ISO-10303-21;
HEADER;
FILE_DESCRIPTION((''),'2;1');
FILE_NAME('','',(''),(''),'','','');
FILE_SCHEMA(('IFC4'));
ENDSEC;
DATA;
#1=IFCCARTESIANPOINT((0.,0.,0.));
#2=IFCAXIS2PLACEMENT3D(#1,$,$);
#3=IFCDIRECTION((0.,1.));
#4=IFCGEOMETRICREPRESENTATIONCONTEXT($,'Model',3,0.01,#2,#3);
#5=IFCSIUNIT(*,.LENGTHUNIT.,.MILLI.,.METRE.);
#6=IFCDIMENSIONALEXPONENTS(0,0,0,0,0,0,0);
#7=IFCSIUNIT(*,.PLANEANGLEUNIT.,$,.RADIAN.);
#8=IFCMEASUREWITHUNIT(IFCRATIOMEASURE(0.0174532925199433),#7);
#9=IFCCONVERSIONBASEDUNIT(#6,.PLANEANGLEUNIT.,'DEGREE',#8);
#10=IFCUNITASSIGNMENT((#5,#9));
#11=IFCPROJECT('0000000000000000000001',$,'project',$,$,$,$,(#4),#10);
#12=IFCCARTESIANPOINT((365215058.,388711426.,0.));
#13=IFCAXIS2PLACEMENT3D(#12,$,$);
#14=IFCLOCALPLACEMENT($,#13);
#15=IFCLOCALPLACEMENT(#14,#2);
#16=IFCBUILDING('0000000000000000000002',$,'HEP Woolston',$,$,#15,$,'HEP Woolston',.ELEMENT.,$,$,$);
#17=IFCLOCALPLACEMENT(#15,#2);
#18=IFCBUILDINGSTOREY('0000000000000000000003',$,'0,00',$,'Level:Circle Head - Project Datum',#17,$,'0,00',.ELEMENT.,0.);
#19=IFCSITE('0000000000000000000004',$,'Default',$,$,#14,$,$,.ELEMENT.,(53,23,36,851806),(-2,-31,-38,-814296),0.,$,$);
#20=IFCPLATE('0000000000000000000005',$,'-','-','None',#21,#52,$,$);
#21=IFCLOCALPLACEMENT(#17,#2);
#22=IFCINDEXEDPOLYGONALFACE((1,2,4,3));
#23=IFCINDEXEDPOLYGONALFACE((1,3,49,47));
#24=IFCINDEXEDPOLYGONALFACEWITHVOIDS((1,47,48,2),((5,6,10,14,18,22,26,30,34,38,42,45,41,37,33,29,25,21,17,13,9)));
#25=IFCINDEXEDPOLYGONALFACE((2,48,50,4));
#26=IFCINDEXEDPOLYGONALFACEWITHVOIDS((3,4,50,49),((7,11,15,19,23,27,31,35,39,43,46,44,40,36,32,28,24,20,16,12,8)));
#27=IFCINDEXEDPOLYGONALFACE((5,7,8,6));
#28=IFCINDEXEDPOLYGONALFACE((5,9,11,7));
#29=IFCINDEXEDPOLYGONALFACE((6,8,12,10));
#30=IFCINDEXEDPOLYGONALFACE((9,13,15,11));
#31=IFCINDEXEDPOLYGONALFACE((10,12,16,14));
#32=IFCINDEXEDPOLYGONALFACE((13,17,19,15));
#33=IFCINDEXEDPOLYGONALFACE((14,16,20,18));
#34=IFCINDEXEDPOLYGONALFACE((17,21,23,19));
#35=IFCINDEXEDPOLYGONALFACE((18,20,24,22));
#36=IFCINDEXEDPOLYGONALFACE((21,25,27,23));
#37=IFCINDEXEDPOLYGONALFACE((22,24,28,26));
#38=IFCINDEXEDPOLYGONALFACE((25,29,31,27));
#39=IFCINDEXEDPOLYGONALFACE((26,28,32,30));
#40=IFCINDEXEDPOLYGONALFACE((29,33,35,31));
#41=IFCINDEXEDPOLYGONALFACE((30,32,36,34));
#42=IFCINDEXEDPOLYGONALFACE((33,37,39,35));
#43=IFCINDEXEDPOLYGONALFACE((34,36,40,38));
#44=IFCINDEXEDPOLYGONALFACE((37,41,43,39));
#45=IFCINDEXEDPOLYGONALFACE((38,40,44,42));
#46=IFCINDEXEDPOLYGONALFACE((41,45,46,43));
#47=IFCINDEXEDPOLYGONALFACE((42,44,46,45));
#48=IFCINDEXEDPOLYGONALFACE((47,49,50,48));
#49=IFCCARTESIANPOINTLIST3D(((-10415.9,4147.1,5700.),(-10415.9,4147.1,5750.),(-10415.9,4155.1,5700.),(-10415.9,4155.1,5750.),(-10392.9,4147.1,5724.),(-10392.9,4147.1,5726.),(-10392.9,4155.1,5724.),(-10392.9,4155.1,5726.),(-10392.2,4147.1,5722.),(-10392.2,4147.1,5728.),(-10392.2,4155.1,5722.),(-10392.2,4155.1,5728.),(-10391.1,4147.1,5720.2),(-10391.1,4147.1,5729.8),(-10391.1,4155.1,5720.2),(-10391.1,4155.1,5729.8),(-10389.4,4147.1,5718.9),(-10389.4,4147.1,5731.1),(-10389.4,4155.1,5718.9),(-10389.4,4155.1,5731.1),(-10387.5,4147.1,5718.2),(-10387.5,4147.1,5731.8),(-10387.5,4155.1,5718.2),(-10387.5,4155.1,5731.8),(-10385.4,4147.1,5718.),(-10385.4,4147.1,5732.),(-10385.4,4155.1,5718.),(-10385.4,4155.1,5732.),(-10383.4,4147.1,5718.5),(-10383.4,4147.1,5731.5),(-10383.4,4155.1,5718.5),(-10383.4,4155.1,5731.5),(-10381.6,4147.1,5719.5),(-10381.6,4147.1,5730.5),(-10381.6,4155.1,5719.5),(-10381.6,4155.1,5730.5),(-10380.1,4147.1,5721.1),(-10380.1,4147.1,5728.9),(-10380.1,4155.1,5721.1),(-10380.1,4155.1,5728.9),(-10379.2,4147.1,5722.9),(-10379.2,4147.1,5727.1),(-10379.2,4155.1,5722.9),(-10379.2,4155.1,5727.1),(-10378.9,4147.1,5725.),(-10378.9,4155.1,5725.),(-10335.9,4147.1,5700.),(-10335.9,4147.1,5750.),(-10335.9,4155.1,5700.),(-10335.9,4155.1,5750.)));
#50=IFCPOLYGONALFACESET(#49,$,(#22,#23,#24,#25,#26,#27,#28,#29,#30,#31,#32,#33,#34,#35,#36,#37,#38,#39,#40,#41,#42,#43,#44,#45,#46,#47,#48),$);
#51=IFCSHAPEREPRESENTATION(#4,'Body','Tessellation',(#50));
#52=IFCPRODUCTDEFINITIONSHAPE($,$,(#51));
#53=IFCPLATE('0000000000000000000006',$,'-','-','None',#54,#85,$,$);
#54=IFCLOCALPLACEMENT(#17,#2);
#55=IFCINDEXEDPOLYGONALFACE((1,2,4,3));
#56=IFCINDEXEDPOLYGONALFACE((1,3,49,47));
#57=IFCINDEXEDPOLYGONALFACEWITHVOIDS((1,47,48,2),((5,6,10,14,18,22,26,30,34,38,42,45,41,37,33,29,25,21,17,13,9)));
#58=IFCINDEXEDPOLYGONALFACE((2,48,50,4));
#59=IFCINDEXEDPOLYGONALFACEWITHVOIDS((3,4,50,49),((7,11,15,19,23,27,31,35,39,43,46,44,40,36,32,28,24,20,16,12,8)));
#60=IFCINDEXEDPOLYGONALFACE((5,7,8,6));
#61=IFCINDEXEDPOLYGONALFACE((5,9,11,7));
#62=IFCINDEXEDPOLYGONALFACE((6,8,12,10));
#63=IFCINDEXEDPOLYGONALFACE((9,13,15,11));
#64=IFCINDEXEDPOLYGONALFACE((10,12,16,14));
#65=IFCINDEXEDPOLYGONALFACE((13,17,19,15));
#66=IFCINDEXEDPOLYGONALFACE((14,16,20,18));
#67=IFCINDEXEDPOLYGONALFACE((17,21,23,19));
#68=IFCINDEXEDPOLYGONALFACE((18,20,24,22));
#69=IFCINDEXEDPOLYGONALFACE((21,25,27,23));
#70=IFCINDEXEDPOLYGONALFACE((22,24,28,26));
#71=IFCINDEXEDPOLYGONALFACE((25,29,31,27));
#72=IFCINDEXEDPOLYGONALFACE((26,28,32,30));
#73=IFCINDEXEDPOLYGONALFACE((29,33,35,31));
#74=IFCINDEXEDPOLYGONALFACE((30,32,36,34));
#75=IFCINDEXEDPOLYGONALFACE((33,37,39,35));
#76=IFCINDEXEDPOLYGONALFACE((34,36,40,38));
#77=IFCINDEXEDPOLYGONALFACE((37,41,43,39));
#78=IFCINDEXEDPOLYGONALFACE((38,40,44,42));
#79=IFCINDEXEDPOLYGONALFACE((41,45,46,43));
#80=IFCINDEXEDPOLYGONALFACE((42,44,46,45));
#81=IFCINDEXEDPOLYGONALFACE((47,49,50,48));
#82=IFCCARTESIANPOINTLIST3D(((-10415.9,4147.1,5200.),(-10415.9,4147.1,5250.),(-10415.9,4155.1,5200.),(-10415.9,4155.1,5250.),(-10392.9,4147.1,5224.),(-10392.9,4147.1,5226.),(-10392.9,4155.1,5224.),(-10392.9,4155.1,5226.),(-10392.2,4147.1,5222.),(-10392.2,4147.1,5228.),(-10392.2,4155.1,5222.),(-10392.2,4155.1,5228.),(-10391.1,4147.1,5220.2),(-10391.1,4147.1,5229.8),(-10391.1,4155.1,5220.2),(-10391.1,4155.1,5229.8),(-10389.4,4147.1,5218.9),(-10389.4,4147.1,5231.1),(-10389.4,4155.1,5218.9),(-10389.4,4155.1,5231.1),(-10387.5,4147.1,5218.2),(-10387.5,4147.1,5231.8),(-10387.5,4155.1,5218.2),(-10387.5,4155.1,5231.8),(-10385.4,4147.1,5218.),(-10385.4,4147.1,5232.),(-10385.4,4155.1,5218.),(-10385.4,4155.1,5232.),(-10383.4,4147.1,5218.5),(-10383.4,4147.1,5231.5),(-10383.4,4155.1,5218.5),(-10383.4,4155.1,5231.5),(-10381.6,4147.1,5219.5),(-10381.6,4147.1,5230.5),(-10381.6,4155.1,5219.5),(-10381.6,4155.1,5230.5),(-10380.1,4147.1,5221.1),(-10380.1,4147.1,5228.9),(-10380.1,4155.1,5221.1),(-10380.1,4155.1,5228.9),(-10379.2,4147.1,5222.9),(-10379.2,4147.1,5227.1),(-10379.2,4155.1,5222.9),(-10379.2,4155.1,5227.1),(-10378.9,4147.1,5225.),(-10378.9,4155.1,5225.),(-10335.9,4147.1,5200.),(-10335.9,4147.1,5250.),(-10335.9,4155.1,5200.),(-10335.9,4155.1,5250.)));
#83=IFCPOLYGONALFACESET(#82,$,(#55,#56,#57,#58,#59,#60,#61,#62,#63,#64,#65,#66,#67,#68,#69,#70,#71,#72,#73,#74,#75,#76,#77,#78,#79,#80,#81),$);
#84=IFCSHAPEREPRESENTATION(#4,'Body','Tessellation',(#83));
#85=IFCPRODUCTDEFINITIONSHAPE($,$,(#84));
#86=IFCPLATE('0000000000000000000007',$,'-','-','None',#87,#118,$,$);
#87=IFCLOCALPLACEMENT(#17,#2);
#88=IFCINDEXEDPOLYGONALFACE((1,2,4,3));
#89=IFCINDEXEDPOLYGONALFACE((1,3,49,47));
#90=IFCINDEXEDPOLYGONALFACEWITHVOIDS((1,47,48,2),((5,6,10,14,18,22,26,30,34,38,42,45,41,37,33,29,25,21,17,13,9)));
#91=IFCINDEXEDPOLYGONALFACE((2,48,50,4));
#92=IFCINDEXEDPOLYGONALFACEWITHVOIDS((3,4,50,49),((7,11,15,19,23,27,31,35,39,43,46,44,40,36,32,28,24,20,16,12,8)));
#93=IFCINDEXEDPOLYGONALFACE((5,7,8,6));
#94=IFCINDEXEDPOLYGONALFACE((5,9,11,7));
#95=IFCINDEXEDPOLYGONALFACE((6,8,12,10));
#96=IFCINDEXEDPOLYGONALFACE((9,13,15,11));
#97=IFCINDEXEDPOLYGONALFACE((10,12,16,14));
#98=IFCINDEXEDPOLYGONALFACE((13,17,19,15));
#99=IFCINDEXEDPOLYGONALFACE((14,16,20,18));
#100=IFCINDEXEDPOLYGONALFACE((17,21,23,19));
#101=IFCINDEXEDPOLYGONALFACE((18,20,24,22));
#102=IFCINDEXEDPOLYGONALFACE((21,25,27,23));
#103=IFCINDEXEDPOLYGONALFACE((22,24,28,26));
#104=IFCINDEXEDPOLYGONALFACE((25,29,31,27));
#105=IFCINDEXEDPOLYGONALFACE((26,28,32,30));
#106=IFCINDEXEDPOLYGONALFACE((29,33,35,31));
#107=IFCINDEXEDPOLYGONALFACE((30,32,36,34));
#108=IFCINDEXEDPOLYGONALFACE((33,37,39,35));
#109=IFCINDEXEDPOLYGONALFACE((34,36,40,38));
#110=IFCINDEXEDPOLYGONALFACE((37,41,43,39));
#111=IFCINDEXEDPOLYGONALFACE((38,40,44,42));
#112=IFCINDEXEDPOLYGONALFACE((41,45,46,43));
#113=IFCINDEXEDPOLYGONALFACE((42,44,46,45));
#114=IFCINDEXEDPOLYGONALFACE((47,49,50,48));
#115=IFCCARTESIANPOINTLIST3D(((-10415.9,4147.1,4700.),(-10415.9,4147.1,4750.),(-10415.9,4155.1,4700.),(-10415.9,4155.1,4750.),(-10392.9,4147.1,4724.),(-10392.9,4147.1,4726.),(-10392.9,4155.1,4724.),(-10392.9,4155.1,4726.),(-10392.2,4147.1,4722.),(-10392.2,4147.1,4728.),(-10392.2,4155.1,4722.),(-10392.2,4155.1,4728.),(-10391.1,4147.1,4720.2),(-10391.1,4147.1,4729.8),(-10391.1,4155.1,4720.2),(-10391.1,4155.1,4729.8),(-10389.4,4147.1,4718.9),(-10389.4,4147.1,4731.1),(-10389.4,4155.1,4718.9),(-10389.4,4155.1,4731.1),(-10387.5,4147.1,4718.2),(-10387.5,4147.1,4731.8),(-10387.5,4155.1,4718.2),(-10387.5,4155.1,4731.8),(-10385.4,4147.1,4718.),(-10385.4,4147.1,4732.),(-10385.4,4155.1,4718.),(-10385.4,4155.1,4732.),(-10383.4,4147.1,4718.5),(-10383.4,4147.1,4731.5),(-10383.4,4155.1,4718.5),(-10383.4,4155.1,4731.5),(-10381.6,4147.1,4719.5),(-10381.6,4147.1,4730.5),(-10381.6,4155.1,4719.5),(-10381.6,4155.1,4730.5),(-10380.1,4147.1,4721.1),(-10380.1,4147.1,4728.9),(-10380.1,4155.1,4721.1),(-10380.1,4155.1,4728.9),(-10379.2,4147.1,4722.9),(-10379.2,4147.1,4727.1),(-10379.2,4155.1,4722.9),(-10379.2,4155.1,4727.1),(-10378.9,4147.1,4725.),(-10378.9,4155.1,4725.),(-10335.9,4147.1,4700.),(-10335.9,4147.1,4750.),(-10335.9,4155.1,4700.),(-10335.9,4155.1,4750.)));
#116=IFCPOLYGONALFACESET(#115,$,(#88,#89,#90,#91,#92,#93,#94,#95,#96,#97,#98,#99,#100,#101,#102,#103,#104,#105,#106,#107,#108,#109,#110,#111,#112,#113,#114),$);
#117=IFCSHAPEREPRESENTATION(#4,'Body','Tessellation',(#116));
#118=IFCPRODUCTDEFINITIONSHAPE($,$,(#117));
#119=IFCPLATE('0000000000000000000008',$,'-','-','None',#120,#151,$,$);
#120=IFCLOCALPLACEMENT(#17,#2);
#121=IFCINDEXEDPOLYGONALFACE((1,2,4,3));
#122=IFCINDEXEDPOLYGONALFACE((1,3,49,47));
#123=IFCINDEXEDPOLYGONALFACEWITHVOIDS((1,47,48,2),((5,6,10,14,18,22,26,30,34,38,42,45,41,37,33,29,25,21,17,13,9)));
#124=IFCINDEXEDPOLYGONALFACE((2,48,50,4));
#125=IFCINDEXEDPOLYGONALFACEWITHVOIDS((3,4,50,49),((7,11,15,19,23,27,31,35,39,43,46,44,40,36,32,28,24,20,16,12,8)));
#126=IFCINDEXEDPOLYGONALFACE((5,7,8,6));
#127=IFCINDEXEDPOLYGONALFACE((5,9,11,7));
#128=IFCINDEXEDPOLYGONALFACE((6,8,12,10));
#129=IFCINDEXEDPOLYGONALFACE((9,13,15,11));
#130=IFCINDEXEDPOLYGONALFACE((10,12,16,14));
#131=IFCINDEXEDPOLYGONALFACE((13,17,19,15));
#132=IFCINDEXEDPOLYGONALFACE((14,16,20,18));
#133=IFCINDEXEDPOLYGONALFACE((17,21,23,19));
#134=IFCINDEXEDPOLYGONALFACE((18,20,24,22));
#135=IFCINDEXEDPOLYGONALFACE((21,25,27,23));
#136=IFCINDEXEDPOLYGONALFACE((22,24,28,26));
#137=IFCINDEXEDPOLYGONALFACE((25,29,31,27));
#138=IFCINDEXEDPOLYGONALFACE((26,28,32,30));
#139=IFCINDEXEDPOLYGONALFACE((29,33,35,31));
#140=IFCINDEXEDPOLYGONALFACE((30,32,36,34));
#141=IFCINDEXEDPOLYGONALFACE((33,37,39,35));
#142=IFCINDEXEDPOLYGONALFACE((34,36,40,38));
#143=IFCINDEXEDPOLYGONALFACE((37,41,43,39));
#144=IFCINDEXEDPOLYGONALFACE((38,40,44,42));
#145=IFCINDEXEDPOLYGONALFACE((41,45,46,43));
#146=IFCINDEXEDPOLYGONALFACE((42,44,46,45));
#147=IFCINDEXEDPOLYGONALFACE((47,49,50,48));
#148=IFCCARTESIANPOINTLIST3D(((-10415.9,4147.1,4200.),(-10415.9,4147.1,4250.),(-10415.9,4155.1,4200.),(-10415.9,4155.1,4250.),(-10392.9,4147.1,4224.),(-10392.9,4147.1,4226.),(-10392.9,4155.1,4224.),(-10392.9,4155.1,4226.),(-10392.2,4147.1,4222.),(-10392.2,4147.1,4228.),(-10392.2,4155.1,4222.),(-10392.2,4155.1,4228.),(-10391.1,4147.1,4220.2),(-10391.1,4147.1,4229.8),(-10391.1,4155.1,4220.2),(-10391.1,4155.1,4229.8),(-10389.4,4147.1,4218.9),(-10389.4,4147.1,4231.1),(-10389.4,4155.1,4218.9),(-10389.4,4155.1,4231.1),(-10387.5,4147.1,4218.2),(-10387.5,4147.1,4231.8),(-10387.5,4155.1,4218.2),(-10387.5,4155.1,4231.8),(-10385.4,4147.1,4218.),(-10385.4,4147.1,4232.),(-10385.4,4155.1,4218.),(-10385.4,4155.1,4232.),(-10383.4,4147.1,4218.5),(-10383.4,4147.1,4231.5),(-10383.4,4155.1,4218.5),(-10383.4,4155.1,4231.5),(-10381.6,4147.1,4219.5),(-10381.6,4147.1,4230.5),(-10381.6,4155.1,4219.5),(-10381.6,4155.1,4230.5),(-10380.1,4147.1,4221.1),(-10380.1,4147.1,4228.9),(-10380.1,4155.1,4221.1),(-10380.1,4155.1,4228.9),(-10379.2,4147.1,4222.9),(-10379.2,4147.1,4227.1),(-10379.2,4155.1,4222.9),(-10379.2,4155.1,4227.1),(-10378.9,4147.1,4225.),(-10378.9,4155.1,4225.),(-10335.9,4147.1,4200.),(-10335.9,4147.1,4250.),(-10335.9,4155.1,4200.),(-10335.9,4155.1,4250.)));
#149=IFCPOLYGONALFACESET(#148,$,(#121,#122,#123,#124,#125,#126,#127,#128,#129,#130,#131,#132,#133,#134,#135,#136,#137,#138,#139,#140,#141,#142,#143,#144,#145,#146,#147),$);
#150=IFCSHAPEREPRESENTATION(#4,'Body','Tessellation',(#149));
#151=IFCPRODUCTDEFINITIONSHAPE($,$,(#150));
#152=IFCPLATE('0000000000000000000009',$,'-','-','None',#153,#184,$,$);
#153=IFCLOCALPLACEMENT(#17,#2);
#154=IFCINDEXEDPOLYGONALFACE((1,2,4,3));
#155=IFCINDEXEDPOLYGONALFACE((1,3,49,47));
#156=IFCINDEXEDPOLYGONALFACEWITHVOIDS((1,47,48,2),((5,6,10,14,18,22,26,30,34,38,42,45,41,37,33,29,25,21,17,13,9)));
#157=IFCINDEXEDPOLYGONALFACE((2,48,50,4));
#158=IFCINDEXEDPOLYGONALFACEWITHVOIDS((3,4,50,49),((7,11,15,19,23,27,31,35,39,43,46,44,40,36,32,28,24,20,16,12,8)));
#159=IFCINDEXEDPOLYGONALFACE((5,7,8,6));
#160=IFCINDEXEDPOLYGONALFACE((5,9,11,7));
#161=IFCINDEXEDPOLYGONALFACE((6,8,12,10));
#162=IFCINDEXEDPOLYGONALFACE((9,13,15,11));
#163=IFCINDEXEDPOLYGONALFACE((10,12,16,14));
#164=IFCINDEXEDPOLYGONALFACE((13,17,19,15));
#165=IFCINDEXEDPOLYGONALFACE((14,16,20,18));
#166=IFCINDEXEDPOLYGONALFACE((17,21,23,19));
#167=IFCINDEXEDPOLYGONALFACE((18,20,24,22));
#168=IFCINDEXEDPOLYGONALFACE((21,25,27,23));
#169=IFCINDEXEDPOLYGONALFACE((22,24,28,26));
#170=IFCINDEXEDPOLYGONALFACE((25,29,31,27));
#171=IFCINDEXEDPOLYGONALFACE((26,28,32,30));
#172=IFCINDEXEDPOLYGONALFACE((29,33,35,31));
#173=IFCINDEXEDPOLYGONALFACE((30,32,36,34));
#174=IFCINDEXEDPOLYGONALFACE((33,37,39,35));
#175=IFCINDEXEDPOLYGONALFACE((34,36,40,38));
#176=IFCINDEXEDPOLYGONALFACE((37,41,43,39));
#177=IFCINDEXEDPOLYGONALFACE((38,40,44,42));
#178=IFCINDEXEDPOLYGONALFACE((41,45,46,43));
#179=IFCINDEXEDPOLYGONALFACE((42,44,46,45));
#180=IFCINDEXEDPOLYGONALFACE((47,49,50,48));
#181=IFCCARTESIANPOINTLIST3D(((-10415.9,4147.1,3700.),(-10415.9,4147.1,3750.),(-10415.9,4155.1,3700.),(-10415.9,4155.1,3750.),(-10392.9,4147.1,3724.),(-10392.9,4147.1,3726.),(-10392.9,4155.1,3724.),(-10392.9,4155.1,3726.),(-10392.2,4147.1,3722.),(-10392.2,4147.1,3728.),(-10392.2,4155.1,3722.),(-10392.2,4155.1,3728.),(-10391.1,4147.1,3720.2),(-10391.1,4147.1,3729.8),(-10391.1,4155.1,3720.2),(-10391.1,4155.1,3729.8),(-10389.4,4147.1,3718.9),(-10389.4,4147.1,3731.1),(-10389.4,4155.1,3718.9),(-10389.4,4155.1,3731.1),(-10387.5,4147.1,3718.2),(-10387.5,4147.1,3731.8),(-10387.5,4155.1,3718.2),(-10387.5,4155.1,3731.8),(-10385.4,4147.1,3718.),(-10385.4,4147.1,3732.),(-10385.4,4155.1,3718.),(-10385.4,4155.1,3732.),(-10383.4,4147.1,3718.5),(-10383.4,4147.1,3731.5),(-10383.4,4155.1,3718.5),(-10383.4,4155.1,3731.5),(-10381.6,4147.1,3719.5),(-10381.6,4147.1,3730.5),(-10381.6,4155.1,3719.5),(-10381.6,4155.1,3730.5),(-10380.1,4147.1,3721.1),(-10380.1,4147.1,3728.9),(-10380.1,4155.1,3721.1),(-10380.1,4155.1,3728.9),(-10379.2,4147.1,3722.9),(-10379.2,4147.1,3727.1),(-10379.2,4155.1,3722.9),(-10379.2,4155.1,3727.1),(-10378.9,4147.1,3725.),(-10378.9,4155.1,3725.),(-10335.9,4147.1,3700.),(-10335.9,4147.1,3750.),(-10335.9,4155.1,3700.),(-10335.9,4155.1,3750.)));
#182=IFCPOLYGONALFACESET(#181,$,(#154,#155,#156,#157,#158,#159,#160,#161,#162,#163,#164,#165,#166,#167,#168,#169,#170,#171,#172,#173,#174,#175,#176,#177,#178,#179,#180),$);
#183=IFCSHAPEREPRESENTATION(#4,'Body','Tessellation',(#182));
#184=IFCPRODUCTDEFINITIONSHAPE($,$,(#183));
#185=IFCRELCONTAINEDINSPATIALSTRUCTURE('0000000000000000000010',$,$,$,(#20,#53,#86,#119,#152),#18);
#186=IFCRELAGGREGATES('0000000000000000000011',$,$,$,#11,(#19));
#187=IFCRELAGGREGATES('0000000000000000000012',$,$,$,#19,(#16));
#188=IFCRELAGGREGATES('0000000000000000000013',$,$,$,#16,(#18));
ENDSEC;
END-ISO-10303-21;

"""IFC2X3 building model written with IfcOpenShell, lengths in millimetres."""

from ifc_helpers import new_model, entity, si_unit, converted_unit, direction, frame, origin, origin_with_axes, origin_2d_with_axis, place, context, project, spatial, polyline, circle, outline, extrude, element, save


model = new_model("IFC2X3")

# Units and contexts
model_context = context("Model", 3, precision=0.01, world=origin(), true_north=direction((0.0, 1.0)))
ifc_project = project(units=[si_unit("LENGTHUNIT", "METRE", prefix="MILLI"), converted_unit("PLANEANGLEUNIT", "DEGREE", entity("IfcRatioMeasure", 0.0174532925199433), si_unit("PLANEANGLEUNIT", "RADIAN"), dimensions=[0, 0, 0, 0, 0, 0, 0])], contexts=[model_context])

# Site, building, storey
site_placement = place(None, frame((365215058.0, 388711426.0, 0.0)))
site = spatial("IfcSite", under=ifc_project, at=site_placement, Name="Default", CompositionType="ELEMENT", RefLatitude=(53, 23, 36, 851806), RefLongitude=(-2, -31, -38, -814296), RefElevation=0.0)
building_placement = place(site_placement, origin())
building = spatial("IfcBuilding", under=site, at=building_placement, Name="HEP Woolston", LongName="HEP Woolston", CompositionType="ELEMENT")
storey_placement = place(building_placement, origin())
storey = spatial("IfcBuildingStorey", under=building, at=storey_placement, Name="0,00", ObjectType="Level:Circle Head - Project Datum", LongName="0,00", CompositionType="ELEMENT", Elevation=0.0)

# Plates, openings
plate_1_placement = place(storey_placement, frame((-10335.9, 4147.1, 5750.0), z_axis=(0.0, 1.0, 0.0), x_axis=(-1.0, 0.0, 0.0)))
plate_1 = element("IfcPlate", 1, at=plate_1_placement, inside=storey, Name="-", Description="-", ObjectType="None", context=model_context, shape_type="SweptSolid", body=[
    extrude(outline(polyline([(0.0, 0.0), (0.0, -50.0), (80.0, -50.0), (80.0, 0.0), (0.0, 0.0)])), origin_with_axes(), (0.0, 0.0, 1.0), 8.0),
])
opening_1_placement = place(plate_1_placement, frame((50.0, -25.0, 8.5), z_axis=(0.0, 0.0, -1.0), x_axis=(-1.0, 0.0, 0.0)))
element("IfcOpeningElement", 2, at=opening_1_placement, cuts=plate_1, ObjectType="Opening", context=model_context, shape_type="SweptSolid", body=[
    extrude(circle(Radius=7.0, at=origin_2d_with_axis()), origin(), (0.0, 0.0, 1.0), 9.0),
])
plate_2_placement = place(storey_placement, frame((-10335.9, 4147.1, 5250.0), z_axis=(0.0, 1.0, 0.0), x_axis=(-1.0, 0.0, 0.0)))
plate_2 = element("IfcPlate", 3, at=plate_2_placement, inside=storey, Name="-", Description="-", ObjectType="None", context=model_context, shape_type="SweptSolid", body=[
    extrude(outline(polyline([(0.0, 0.0), (0.0, -50.0), (80.0, -50.0), (80.0, 0.0), (0.0, 0.0)])), origin_with_axes(), (0.0, 0.0, 1.0), 8.0),
])
opening_2_placement = place(plate_2_placement, frame((50.0, -25.0, 8.5), z_axis=(0.0, 0.0, -1.0), x_axis=(-1.0, 0.0, 0.0)))
element("IfcOpeningElement", 4, at=opening_2_placement, cuts=plate_2, ObjectType="Opening", context=model_context, shape_type="SweptSolid", body=[
    extrude(circle(Radius=7.0, at=origin_2d_with_axis()), origin(), (0.0, 0.0, 1.0), 9.0),
])
plate_3_placement = place(storey_placement, frame((-10335.9, 4147.1, 4750.0), z_axis=(0.0, 1.0, 0.0), x_axis=(-1.0, 0.0, 0.0)))
plate_3 = element("IfcPlate", 5, at=plate_3_placement, inside=storey, Name="-", Description="-", ObjectType="None", context=model_context, shape_type="SweptSolid", body=[
    extrude(outline(polyline([(0.0, 0.0), (0.0, -50.0), (80.0, -50.0), (80.0, 0.0), (0.0, 0.0)])), origin_with_axes(), (0.0, 0.0, 1.0), 8.0),
])
opening_3_placement = place(plate_3_placement, frame((50.0, -25.0, 8.5), z_axis=(0.0, 0.0, -1.0), x_axis=(-1.0, 0.0, 0.0)))
element("IfcOpeningElement", 6, at=opening_3_placement, cuts=plate_3, ObjectType="Opening", context=model_context, shape_type="SweptSolid", body=[
    extrude(circle(Radius=7.0, at=origin_2d_with_axis()), origin(), (0.0, 0.0, 1.0), 9.0),
])
plate_4_placement = place(storey_placement, frame((-10335.9, 4147.1, 4250.0), z_axis=(0.0, 1.0, 0.0), x_axis=(-1.0, 0.0, 0.0)))
plate_4 = element("IfcPlate", 7, at=plate_4_placement, inside=storey, Name="-", Description="-", ObjectType="None", context=model_context, shape_type="SweptSolid", body=[
    extrude(outline(polyline([(0.0, 0.0), (0.0, -50.0), (80.0, -50.0), (80.0, 0.0), (0.0, 0.0)])), origin_with_axes(), (0.0, 0.0, 1.0), 8.0),
])
opening_4_placement = place(plate_4_placement, frame((50.0, -25.0, 8.5), z_axis=(0.0, 0.0, -1.0), x_axis=(-1.0, 0.0, 0.0)))
element("IfcOpeningElement", 8, at=opening_4_placement, cuts=plate_4, ObjectType="Opening", context=model_context, shape_type="SweptSolid", body=[
    extrude(circle(Radius=7.0, at=origin_2d_with_axis()), origin(), (0.0, 0.0, 1.0), 9.0),
])
plate_5_placement = place(storey_placement, frame((-10335.9, 4147.1, 3750.0), z_axis=(0.0, 1.0, 0.0), x_axis=(-1.0, 0.0, 0.0)))
plate_5 = element("IfcPlate", 9, at=plate_5_placement, inside=storey, Name="-", Description="-", ObjectType="None", context=model_context, shape_type="SweptSolid", body=[
    extrude(outline(polyline([(0.0, 0.0), (0.0, -50.0), (80.0, -50.0), (80.0, 0.0), (0.0, 0.0)])), origin_with_axes(), (0.0, 0.0, 1.0), 8.0),
])
opening_5_placement = place(plate_5_placement, frame((50.0, -25.0, 8.5), z_axis=(0.0, 0.0, -1.0), x_axis=(-1.0, 0.0, 0.0)))
element("IfcOpeningElement", 10, at=opening_5_placement, cuts=plate_5, ObjectType="Opening", context=model_context, shape_type="SweptSolid", body=[
    extrude(circle(Radius=7.0, at=origin_2d_with_axis()), origin(), (0.0, 0.0, 1.0), 9.0),
])

save(model, "model.ifc")
